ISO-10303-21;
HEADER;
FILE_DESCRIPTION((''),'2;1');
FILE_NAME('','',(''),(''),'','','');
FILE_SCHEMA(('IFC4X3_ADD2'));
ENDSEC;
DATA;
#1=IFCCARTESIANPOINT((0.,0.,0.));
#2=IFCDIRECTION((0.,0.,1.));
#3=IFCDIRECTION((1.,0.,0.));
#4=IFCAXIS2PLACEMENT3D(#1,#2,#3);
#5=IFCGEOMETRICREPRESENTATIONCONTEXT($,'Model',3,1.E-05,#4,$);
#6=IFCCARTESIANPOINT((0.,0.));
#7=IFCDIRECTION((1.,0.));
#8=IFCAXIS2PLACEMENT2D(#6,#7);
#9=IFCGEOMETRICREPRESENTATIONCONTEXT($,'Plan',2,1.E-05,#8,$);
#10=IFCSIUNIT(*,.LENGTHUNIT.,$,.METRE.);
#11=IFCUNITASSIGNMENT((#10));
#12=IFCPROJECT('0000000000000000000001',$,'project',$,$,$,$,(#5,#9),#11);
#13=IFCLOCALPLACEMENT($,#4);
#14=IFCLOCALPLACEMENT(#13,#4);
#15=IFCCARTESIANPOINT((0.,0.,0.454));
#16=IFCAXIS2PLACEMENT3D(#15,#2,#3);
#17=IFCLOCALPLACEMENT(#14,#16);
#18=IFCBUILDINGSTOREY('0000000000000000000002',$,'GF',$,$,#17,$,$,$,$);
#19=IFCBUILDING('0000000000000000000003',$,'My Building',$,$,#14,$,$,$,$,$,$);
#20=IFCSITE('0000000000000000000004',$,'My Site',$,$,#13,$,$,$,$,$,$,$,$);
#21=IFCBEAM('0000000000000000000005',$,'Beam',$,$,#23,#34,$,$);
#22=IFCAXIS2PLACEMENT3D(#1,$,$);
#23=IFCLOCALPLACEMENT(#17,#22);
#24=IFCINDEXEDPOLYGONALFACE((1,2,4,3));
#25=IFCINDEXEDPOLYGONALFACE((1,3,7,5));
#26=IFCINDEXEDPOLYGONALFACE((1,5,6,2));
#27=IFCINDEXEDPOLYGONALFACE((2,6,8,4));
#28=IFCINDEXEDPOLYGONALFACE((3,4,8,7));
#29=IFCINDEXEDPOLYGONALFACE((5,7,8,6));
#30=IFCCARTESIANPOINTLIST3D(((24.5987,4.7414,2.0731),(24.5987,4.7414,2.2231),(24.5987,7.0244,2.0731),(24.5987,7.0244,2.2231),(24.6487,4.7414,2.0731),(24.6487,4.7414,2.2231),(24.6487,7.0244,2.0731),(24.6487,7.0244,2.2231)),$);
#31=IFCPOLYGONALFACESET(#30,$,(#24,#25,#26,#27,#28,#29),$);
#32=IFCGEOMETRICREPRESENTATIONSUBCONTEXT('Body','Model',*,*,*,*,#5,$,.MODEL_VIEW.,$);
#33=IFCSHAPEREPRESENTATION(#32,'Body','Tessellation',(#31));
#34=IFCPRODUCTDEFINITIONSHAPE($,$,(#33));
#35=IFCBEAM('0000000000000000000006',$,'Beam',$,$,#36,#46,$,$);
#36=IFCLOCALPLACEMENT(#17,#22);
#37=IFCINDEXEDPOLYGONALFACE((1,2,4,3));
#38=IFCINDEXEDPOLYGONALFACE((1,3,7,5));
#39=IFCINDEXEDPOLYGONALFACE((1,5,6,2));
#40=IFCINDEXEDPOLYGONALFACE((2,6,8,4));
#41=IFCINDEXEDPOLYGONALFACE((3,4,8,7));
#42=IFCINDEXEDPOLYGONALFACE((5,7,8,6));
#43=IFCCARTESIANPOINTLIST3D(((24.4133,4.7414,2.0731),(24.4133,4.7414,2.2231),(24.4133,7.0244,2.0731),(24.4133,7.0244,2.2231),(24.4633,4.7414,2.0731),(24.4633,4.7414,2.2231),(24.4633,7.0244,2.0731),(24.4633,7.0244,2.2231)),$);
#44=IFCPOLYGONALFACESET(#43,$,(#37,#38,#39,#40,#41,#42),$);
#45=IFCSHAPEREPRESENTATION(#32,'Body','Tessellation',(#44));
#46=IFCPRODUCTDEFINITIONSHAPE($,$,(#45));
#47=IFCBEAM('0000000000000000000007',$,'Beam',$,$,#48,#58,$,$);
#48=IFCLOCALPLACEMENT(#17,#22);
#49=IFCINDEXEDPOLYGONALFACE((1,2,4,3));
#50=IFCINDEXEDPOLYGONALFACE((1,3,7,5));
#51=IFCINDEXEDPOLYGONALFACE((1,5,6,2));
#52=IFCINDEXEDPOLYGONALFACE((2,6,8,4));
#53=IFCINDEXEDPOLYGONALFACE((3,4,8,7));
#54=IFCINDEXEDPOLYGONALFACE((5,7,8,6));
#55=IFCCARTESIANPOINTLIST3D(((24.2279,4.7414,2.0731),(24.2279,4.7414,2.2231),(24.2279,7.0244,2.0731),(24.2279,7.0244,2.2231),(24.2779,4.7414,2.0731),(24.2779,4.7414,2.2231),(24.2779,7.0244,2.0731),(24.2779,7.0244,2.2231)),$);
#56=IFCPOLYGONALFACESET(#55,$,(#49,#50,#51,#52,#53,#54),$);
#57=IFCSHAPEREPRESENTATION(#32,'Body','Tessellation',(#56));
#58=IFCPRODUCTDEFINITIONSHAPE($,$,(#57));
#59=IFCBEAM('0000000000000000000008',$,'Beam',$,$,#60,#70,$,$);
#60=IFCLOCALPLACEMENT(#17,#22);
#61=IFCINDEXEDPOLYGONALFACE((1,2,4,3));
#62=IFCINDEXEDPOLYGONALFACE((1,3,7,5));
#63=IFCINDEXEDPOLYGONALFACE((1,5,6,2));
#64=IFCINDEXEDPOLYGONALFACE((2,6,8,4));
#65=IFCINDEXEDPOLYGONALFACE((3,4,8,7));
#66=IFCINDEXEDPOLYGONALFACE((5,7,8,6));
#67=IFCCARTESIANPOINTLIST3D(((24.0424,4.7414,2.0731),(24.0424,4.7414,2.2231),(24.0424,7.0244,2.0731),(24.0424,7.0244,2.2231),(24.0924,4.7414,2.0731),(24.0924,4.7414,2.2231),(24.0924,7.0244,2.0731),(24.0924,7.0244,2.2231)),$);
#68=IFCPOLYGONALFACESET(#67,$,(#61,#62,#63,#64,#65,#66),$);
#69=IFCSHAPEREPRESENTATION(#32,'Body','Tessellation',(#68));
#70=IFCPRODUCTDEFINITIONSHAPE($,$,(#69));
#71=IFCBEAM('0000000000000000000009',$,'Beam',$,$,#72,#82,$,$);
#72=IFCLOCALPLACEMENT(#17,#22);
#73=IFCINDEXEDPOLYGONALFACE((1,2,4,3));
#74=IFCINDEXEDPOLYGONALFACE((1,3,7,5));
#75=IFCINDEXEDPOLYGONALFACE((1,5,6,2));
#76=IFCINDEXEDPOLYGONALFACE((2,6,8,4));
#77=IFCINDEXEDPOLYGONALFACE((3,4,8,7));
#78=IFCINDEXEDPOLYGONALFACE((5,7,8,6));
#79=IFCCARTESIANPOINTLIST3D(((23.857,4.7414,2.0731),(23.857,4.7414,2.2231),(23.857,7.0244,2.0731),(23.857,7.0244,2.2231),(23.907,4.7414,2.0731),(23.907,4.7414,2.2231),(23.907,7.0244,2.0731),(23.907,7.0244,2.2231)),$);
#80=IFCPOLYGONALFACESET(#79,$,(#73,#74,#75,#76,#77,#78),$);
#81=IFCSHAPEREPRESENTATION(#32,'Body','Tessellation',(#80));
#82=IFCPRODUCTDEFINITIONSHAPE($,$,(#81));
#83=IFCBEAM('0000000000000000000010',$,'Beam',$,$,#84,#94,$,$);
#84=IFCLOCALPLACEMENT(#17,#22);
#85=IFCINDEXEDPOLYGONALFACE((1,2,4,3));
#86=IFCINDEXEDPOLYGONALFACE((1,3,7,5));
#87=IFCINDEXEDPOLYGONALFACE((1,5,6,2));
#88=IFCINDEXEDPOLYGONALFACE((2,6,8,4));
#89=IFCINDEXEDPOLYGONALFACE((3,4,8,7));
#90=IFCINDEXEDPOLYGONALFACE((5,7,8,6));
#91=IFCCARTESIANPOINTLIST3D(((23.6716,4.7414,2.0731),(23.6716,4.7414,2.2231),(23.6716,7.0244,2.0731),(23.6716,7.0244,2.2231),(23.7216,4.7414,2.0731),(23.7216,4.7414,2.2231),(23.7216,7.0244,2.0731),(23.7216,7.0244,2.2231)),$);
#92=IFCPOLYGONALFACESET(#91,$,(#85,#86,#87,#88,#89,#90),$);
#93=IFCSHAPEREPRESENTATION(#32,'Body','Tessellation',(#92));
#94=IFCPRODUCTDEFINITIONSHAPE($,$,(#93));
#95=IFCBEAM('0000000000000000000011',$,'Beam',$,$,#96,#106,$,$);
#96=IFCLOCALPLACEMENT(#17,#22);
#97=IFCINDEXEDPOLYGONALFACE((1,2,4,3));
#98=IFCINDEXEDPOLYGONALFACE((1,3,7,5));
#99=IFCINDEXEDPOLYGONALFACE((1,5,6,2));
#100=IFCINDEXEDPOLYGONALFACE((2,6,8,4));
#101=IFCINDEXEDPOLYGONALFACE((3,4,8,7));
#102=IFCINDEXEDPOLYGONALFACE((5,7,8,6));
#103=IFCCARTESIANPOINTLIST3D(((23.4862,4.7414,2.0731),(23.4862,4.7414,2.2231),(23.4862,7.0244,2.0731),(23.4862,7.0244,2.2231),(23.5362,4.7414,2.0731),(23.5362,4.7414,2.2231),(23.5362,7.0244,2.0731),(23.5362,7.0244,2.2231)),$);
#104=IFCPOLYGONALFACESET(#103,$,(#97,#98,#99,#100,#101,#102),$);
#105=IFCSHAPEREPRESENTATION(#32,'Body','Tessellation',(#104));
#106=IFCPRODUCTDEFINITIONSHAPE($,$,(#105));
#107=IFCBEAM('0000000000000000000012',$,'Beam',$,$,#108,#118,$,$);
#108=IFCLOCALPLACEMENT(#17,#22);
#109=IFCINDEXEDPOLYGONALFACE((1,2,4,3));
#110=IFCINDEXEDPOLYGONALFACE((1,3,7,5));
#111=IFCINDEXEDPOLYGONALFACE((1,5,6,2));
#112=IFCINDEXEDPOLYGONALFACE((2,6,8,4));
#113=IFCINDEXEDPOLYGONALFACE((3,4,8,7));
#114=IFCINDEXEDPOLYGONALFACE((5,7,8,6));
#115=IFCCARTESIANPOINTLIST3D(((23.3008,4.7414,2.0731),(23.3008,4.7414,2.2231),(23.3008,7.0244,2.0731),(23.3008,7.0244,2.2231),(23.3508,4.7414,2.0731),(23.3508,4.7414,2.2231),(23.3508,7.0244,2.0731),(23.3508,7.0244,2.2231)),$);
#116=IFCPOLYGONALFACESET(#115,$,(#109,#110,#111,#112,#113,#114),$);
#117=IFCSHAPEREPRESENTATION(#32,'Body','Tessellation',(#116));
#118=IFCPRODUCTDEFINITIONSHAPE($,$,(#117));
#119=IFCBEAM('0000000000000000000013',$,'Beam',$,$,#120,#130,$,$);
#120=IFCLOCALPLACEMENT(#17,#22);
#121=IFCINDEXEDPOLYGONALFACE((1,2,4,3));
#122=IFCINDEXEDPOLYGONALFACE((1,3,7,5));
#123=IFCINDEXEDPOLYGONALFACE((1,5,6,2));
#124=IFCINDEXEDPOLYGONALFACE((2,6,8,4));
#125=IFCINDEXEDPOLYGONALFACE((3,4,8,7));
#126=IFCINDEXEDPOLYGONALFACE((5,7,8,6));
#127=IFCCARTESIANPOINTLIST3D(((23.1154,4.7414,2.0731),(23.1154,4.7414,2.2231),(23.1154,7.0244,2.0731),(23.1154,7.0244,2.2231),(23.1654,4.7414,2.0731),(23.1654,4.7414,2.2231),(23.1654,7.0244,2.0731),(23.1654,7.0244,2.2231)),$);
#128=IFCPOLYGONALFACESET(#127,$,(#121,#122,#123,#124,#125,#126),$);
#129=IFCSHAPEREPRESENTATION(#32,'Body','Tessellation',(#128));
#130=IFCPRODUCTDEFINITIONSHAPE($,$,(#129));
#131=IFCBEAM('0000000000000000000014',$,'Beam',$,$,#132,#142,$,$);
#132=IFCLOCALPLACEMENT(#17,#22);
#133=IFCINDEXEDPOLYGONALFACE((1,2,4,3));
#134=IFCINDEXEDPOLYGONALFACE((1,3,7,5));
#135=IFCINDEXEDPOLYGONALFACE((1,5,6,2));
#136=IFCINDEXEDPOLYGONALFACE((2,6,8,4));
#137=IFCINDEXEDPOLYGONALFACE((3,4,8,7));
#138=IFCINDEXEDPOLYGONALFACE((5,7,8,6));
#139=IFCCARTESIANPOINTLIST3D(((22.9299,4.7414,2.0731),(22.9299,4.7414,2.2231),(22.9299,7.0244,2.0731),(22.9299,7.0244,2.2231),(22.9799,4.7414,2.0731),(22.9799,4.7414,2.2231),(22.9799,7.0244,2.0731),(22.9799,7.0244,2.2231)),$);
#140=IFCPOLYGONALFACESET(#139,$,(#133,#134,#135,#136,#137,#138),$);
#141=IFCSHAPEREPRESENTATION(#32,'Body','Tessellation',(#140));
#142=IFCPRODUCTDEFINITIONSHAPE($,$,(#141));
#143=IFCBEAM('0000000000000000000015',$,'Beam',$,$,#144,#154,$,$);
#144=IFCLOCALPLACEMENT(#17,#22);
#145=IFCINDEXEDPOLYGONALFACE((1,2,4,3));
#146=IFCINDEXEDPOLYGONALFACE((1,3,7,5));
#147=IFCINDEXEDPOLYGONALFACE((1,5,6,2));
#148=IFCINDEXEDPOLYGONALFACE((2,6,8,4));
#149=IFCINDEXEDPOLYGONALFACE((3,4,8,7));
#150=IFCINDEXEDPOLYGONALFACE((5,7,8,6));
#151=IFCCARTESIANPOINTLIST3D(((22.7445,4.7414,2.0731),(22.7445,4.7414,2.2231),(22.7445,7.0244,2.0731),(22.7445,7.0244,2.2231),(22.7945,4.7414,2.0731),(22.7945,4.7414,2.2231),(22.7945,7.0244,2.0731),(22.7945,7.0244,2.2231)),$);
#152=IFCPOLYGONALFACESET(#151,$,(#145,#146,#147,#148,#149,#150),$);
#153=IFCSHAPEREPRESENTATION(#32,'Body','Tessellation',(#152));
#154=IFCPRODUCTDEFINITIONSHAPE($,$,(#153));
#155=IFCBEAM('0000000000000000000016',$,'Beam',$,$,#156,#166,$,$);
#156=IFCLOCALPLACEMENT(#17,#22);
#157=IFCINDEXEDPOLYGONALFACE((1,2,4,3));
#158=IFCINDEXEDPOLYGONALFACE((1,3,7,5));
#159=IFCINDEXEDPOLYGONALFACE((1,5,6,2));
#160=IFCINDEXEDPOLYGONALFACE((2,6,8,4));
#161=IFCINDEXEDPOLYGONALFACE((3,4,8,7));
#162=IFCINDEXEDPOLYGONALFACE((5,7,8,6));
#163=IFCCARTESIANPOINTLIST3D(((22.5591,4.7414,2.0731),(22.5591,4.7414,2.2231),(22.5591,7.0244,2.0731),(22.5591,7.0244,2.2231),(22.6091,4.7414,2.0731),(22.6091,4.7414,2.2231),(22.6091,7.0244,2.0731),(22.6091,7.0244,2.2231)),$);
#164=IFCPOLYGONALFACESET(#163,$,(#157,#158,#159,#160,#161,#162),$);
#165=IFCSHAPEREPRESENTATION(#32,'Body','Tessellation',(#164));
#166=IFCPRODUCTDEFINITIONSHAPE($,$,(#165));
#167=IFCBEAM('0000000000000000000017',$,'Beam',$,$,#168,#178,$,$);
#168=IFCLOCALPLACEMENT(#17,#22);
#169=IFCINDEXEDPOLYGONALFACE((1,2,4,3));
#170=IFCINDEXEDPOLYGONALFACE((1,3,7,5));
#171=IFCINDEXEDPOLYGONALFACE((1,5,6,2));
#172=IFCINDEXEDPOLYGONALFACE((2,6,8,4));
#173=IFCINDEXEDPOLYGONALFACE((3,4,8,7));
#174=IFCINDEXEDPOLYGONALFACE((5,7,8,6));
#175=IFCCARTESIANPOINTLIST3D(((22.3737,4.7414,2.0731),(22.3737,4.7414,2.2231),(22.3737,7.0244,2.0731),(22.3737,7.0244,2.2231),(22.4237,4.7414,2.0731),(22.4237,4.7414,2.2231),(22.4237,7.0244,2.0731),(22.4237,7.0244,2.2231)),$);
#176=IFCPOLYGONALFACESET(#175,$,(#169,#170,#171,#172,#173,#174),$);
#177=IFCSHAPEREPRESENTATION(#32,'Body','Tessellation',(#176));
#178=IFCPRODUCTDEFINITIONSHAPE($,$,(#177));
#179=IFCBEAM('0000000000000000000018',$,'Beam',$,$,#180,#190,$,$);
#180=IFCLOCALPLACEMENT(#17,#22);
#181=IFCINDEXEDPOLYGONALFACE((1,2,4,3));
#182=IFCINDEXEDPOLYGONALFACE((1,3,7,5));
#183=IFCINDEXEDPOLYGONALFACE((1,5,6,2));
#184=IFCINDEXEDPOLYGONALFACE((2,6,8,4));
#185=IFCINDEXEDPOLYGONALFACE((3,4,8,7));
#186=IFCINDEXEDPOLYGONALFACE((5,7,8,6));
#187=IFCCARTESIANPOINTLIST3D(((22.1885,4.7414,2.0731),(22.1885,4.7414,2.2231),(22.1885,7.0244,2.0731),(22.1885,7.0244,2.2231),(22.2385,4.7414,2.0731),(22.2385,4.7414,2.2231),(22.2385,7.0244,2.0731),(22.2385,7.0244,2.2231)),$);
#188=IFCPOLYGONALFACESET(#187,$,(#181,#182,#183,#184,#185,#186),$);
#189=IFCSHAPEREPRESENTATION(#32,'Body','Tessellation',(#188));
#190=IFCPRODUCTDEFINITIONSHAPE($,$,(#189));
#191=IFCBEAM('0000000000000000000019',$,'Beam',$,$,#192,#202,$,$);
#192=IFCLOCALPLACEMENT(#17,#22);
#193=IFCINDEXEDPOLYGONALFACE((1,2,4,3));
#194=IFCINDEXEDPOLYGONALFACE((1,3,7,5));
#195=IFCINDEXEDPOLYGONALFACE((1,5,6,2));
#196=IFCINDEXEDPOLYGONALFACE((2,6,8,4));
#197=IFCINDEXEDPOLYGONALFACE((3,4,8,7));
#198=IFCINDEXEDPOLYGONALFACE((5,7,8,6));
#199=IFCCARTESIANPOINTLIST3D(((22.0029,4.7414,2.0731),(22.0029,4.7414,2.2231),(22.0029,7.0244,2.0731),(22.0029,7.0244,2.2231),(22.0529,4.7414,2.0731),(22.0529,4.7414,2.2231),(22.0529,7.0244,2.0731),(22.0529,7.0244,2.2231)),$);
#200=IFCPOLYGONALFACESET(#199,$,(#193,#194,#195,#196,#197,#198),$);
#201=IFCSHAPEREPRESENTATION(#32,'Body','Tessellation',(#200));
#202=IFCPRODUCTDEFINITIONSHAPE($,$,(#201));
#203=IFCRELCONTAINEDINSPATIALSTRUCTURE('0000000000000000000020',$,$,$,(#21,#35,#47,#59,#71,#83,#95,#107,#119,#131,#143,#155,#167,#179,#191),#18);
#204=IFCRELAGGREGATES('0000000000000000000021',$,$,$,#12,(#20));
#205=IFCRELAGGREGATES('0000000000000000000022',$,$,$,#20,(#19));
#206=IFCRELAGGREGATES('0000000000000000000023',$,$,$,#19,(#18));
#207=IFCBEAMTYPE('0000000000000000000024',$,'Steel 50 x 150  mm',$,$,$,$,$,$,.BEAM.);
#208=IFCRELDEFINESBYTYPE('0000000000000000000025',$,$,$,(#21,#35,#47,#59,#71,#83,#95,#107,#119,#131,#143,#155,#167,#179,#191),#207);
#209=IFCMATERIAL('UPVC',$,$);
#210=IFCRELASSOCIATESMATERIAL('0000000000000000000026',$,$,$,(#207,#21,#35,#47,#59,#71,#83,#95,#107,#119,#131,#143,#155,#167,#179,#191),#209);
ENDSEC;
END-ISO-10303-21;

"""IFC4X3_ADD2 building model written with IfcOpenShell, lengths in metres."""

from ifc_helpers import new_model, si_unit, frame, origin_with_axes, origin_2d_with_axis, place, context, subcontext, project, spatial, rectangle, extrude, material, material_profile, profile_set, profile_usage, type_object, element, save


model = new_model("IFC4X3_ADD2")

# Units and contexts
model_context = context("Model", 3, precision=1e-05, world=origin_with_axes())
plan_context = context("Plan", 2, precision=1e-05, world=origin_2d_with_axis())
body_context_1 = subcontext(model_context, "Body", "Model", "MODEL_VIEW")
ifc_project = project(units=[si_unit("LENGTHUNIT", "METRE")], contexts=[model_context, plan_context])

# Site, building, storey
site_placement = place(None, origin_with_axes())
site = spatial("IfcSite", under=ifc_project, at=site_placement, Name="My Site")
building_placement = place(site_placement, origin_with_axes())
building = spatial("IfcBuilding", under=site, at=building_placement, Name="My Building")
storey_placement = place(building_placement, frame((0.0, 0.0, 0.454), z_axis=(0.0, 0.0, 1.0), x_axis=(1.0, 0.0, 0.0)))
storey = spatial("IfcBuildingStorey", under=building, at=storey_placement, Name="GF")

# Beams
ifc_material = material(Name="UPVC")
ifc_material_profile = material_profile(ifc_material, rectangle(XDim=0.05, YDim=0.15))
ifc_profile_set = profile_set([ifc_material_profile])
ifc_profile_usage_1 = profile_usage(ifc_profile_set)
beam_type = type_object("IfcBeamType", Name="Steel 50 x 150  mm", PredefinedType="BEAM", material=ifc_profile_set)
beam_1_placement = place(storey_placement, frame((24.6237, 7.0244, 2.1481), z_axis=(0.0, -1.0, 0.0), x_axis=(1.0, 0.0, 0.0)))
element("IfcBeam", 1, at=beam_1_placement, inside=storey, type_object=beam_type, material=ifc_profile_usage_1, Name="Beam", context=body_context_1, shape_type="SweptSolid", body=[
    extrude(rectangle(XDim=0.05, YDim=0.15), origin_with_axes(), (0.0, 0.0, 1.0), 2.283),
])
ifc_profile_usage_2 = profile_usage(ifc_profile_set)
beam_2_placement = place(storey_placement, frame((24.4383, 7.0244, 2.1481), z_axis=(0.0, -1.0, 0.0), x_axis=(1.0, 0.0, 0.0)))
element("IfcBeam", 2, at=beam_2_placement, inside=storey, type_object=beam_type, material=ifc_profile_usage_2, Name="Beam", context=body_context_1, shape_type="SweptSolid", body=[
    extrude(rectangle(XDim=0.05, YDim=0.15), origin_with_axes(), (0.0, 0.0, 1.0), 2.283),
])
ifc_profile_usage_3 = profile_usage(ifc_profile_set)
beam_3_placement = place(storey_placement, frame((24.2529, 7.0244, 2.1481), z_axis=(0.0, -1.0, 0.0), x_axis=(1.0, 0.0, 0.0)))
element("IfcBeam", 3, at=beam_3_placement, inside=storey, type_object=beam_type, material=ifc_profile_usage_3, Name="Beam", context=body_context_1, shape_type="SweptSolid", body=[
    extrude(rectangle(XDim=0.05, YDim=0.15), origin_with_axes(), (0.0, 0.0, 1.0), 2.283),
])
ifc_profile_usage_4 = profile_usage(ifc_profile_set)
beam_4_placement = place(storey_placement, frame((24.0674, 7.0244, 2.1481), z_axis=(0.0, -1.0, 0.0), x_axis=(1.0, 0.0, 0.0)))
element("IfcBeam", 4, at=beam_4_placement, inside=storey, type_object=beam_type, material=ifc_profile_usage_4, Name="Beam", context=body_context_1, shape_type="SweptSolid", body=[
    extrude(rectangle(XDim=0.05, YDim=0.15), origin_with_axes(), (0.0, 0.0, 1.0), 2.283),
])
ifc_profile_usage_5 = profile_usage(ifc_profile_set)
beam_5_placement = place(storey_placement, frame((23.882, 7.0244, 2.1481), z_axis=(0.0, -1.0, 0.0), x_axis=(1.0, 0.0, 0.0)))
element("IfcBeam", 5, at=beam_5_placement, inside=storey, type_object=beam_type, material=ifc_profile_usage_5, Name="Beam", context=body_context_1, shape_type="SweptSolid", body=[
    extrude(rectangle(XDim=0.05, YDim=0.15), origin_with_axes(), (0.0, 0.0, 1.0), 2.283),
])
ifc_profile_usage_6 = profile_usage(ifc_profile_set)
beam_6_placement = place(storey_placement, frame((23.6966, 7.0244, 2.1481), z_axis=(0.0, -1.0, 0.0), x_axis=(1.0, 0.0, 0.0)))
element("IfcBeam", 6, at=beam_6_placement, inside=storey, type_object=beam_type, material=ifc_profile_usage_6, Name="Beam", context=body_context_1, shape_type="SweptSolid", body=[
    extrude(rectangle(XDim=0.05, YDim=0.15), origin_with_axes(), (0.0, 0.0, 1.0), 2.283),
])
ifc_profile_usage_7 = profile_usage(ifc_profile_set)
beam_7_placement = place(storey_placement, frame((23.5112, 7.0244, 2.1481), z_axis=(0.0, -1.0, 0.0), x_axis=(1.0, 0.0, 0.0)))
element("IfcBeam", 7, at=beam_7_placement, inside=storey, type_object=beam_type, material=ifc_profile_usage_7, Name="Beam", context=body_context_1, shape_type="SweptSolid", body=[
    extrude(rectangle(XDim=0.05, YDim=0.15), origin_with_axes(), (0.0, 0.0, 1.0), 2.283),
])
ifc_profile_usage_8 = profile_usage(ifc_profile_set)
beam_8_placement = place(storey_placement, frame((23.3258, 7.0244, 2.1481), z_axis=(0.0, -1.0, 0.0), x_axis=(1.0, 0.0, 0.0)))
element("IfcBeam", 8, at=beam_8_placement, inside=storey, type_object=beam_type, material=ifc_profile_usage_8, Name="Beam", context=body_context_1, shape_type="SweptSolid", body=[
    extrude(rectangle(XDim=0.05, YDim=0.15), origin_with_axes(), (0.0, 0.0, 1.0), 2.283),
])
ifc_profile_usage_9 = profile_usage(ifc_profile_set)
beam_9_placement = place(storey_placement, frame((23.1404, 7.0244, 2.1481), z_axis=(0.0, -1.0, 0.0), x_axis=(1.0, 0.0, 0.0)))
element("IfcBeam", 9, at=beam_9_placement, inside=storey, type_object=beam_type, material=ifc_profile_usage_9, Name="Beam", context=body_context_1, shape_type="SweptSolid", body=[
    extrude(rectangle(XDim=0.05, YDim=0.15), origin_with_axes(), (0.0, 0.0, 1.0), 2.283),
])
ifc_profile_usage_10 = profile_usage(ifc_profile_set)
beam_10_placement = place(storey_placement, frame((22.9549, 7.0244, 2.1481), z_axis=(0.0, -1.0, 0.0), x_axis=(1.0, 0.0, 0.0)))
element("IfcBeam", 10, at=beam_10_placement, inside=storey, type_object=beam_type, material=ifc_profile_usage_10, Name="Beam", context=body_context_1, shape_type="SweptSolid", body=[
    extrude(rectangle(XDim=0.05, YDim=0.15), origin_with_axes(), (0.0, 0.0, 1.0), 2.283),
])
ifc_profile_usage_11 = profile_usage(ifc_profile_set)
beam_11_placement = place(storey_placement, frame((22.7695, 7.0244, 2.1481), z_axis=(0.0, -1.0, 0.0), x_axis=(1.0, 0.0, 0.0)))
element("IfcBeam", 11, at=beam_11_placement, inside=storey, type_object=beam_type, material=ifc_profile_usage_11, Name="Beam", context=body_context_1, shape_type="SweptSolid", body=[
    extrude(rectangle(XDim=0.05, YDim=0.15), origin_with_axes(), (0.0, 0.0, 1.0), 2.283),
])
ifc_profile_usage_12 = profile_usage(ifc_profile_set)
beam_12_placement = place(storey_placement, frame((22.5841, 7.0244, 2.1481), z_axis=(0.0, -1.0, 0.0), x_axis=(1.0, 0.0, 0.0)))
element("IfcBeam", 12, at=beam_12_placement, inside=storey, type_object=beam_type, material=ifc_profile_usage_12, Name="Beam", context=body_context_1, shape_type="SweptSolid", body=[
    extrude(rectangle(XDim=0.05, YDim=0.15), origin_with_axes(), (0.0, 0.0, 1.0), 2.283),
])
ifc_profile_usage_13 = profile_usage(ifc_profile_set)
beam_13_placement = place(storey_placement, frame((22.3987, 7.0244, 2.1481), z_axis=(0.0, -1.0, 0.0), x_axis=(1.0, 0.0, 0.0)))
element("IfcBeam", 13, at=beam_13_placement, inside=storey, type_object=beam_type, material=ifc_profile_usage_13, Name="Beam", context=body_context_1, shape_type="SweptSolid", body=[
    extrude(rectangle(XDim=0.05, YDim=0.15), origin_with_axes(), (0.0, 0.0, 1.0), 2.283),
])
ifc_profile_usage_14 = profile_usage(ifc_profile_set)
beam_14_placement = place(storey_placement, frame((22.2135, 7.0244, 2.1481), z_axis=(0.0, -1.0, 0.0), x_axis=(1.0, 0.0, 0.0)))
element("IfcBeam", 14, at=beam_14_placement, inside=storey, type_object=beam_type, material=ifc_profile_usage_14, Name="Beam", context=body_context_1, shape_type="SweptSolid", body=[
    extrude(rectangle(XDim=0.05, YDim=0.15), origin_with_axes(), (0.0, 0.0, 1.0), 2.283),
])
ifc_profile_usage_15 = profile_usage(ifc_profile_set)
beam_15_placement = place(storey_placement, frame((22.0279, 7.0244, 2.1481), z_axis=(0.0, -1.0, 0.0), x_axis=(1.0, 0.0, 0.0)))
element("IfcBeam", 15, at=beam_15_placement, inside=storey, type_object=beam_type, material=ifc_profile_usage_15, Name="Beam", context=body_context_1, shape_type="SweptSolid", body=[
    extrude(rectangle(XDim=0.05, YDim=0.15), origin_with_axes(), (0.0, 0.0, 1.0), 2.283),
])

save(model, "model.ifc")
